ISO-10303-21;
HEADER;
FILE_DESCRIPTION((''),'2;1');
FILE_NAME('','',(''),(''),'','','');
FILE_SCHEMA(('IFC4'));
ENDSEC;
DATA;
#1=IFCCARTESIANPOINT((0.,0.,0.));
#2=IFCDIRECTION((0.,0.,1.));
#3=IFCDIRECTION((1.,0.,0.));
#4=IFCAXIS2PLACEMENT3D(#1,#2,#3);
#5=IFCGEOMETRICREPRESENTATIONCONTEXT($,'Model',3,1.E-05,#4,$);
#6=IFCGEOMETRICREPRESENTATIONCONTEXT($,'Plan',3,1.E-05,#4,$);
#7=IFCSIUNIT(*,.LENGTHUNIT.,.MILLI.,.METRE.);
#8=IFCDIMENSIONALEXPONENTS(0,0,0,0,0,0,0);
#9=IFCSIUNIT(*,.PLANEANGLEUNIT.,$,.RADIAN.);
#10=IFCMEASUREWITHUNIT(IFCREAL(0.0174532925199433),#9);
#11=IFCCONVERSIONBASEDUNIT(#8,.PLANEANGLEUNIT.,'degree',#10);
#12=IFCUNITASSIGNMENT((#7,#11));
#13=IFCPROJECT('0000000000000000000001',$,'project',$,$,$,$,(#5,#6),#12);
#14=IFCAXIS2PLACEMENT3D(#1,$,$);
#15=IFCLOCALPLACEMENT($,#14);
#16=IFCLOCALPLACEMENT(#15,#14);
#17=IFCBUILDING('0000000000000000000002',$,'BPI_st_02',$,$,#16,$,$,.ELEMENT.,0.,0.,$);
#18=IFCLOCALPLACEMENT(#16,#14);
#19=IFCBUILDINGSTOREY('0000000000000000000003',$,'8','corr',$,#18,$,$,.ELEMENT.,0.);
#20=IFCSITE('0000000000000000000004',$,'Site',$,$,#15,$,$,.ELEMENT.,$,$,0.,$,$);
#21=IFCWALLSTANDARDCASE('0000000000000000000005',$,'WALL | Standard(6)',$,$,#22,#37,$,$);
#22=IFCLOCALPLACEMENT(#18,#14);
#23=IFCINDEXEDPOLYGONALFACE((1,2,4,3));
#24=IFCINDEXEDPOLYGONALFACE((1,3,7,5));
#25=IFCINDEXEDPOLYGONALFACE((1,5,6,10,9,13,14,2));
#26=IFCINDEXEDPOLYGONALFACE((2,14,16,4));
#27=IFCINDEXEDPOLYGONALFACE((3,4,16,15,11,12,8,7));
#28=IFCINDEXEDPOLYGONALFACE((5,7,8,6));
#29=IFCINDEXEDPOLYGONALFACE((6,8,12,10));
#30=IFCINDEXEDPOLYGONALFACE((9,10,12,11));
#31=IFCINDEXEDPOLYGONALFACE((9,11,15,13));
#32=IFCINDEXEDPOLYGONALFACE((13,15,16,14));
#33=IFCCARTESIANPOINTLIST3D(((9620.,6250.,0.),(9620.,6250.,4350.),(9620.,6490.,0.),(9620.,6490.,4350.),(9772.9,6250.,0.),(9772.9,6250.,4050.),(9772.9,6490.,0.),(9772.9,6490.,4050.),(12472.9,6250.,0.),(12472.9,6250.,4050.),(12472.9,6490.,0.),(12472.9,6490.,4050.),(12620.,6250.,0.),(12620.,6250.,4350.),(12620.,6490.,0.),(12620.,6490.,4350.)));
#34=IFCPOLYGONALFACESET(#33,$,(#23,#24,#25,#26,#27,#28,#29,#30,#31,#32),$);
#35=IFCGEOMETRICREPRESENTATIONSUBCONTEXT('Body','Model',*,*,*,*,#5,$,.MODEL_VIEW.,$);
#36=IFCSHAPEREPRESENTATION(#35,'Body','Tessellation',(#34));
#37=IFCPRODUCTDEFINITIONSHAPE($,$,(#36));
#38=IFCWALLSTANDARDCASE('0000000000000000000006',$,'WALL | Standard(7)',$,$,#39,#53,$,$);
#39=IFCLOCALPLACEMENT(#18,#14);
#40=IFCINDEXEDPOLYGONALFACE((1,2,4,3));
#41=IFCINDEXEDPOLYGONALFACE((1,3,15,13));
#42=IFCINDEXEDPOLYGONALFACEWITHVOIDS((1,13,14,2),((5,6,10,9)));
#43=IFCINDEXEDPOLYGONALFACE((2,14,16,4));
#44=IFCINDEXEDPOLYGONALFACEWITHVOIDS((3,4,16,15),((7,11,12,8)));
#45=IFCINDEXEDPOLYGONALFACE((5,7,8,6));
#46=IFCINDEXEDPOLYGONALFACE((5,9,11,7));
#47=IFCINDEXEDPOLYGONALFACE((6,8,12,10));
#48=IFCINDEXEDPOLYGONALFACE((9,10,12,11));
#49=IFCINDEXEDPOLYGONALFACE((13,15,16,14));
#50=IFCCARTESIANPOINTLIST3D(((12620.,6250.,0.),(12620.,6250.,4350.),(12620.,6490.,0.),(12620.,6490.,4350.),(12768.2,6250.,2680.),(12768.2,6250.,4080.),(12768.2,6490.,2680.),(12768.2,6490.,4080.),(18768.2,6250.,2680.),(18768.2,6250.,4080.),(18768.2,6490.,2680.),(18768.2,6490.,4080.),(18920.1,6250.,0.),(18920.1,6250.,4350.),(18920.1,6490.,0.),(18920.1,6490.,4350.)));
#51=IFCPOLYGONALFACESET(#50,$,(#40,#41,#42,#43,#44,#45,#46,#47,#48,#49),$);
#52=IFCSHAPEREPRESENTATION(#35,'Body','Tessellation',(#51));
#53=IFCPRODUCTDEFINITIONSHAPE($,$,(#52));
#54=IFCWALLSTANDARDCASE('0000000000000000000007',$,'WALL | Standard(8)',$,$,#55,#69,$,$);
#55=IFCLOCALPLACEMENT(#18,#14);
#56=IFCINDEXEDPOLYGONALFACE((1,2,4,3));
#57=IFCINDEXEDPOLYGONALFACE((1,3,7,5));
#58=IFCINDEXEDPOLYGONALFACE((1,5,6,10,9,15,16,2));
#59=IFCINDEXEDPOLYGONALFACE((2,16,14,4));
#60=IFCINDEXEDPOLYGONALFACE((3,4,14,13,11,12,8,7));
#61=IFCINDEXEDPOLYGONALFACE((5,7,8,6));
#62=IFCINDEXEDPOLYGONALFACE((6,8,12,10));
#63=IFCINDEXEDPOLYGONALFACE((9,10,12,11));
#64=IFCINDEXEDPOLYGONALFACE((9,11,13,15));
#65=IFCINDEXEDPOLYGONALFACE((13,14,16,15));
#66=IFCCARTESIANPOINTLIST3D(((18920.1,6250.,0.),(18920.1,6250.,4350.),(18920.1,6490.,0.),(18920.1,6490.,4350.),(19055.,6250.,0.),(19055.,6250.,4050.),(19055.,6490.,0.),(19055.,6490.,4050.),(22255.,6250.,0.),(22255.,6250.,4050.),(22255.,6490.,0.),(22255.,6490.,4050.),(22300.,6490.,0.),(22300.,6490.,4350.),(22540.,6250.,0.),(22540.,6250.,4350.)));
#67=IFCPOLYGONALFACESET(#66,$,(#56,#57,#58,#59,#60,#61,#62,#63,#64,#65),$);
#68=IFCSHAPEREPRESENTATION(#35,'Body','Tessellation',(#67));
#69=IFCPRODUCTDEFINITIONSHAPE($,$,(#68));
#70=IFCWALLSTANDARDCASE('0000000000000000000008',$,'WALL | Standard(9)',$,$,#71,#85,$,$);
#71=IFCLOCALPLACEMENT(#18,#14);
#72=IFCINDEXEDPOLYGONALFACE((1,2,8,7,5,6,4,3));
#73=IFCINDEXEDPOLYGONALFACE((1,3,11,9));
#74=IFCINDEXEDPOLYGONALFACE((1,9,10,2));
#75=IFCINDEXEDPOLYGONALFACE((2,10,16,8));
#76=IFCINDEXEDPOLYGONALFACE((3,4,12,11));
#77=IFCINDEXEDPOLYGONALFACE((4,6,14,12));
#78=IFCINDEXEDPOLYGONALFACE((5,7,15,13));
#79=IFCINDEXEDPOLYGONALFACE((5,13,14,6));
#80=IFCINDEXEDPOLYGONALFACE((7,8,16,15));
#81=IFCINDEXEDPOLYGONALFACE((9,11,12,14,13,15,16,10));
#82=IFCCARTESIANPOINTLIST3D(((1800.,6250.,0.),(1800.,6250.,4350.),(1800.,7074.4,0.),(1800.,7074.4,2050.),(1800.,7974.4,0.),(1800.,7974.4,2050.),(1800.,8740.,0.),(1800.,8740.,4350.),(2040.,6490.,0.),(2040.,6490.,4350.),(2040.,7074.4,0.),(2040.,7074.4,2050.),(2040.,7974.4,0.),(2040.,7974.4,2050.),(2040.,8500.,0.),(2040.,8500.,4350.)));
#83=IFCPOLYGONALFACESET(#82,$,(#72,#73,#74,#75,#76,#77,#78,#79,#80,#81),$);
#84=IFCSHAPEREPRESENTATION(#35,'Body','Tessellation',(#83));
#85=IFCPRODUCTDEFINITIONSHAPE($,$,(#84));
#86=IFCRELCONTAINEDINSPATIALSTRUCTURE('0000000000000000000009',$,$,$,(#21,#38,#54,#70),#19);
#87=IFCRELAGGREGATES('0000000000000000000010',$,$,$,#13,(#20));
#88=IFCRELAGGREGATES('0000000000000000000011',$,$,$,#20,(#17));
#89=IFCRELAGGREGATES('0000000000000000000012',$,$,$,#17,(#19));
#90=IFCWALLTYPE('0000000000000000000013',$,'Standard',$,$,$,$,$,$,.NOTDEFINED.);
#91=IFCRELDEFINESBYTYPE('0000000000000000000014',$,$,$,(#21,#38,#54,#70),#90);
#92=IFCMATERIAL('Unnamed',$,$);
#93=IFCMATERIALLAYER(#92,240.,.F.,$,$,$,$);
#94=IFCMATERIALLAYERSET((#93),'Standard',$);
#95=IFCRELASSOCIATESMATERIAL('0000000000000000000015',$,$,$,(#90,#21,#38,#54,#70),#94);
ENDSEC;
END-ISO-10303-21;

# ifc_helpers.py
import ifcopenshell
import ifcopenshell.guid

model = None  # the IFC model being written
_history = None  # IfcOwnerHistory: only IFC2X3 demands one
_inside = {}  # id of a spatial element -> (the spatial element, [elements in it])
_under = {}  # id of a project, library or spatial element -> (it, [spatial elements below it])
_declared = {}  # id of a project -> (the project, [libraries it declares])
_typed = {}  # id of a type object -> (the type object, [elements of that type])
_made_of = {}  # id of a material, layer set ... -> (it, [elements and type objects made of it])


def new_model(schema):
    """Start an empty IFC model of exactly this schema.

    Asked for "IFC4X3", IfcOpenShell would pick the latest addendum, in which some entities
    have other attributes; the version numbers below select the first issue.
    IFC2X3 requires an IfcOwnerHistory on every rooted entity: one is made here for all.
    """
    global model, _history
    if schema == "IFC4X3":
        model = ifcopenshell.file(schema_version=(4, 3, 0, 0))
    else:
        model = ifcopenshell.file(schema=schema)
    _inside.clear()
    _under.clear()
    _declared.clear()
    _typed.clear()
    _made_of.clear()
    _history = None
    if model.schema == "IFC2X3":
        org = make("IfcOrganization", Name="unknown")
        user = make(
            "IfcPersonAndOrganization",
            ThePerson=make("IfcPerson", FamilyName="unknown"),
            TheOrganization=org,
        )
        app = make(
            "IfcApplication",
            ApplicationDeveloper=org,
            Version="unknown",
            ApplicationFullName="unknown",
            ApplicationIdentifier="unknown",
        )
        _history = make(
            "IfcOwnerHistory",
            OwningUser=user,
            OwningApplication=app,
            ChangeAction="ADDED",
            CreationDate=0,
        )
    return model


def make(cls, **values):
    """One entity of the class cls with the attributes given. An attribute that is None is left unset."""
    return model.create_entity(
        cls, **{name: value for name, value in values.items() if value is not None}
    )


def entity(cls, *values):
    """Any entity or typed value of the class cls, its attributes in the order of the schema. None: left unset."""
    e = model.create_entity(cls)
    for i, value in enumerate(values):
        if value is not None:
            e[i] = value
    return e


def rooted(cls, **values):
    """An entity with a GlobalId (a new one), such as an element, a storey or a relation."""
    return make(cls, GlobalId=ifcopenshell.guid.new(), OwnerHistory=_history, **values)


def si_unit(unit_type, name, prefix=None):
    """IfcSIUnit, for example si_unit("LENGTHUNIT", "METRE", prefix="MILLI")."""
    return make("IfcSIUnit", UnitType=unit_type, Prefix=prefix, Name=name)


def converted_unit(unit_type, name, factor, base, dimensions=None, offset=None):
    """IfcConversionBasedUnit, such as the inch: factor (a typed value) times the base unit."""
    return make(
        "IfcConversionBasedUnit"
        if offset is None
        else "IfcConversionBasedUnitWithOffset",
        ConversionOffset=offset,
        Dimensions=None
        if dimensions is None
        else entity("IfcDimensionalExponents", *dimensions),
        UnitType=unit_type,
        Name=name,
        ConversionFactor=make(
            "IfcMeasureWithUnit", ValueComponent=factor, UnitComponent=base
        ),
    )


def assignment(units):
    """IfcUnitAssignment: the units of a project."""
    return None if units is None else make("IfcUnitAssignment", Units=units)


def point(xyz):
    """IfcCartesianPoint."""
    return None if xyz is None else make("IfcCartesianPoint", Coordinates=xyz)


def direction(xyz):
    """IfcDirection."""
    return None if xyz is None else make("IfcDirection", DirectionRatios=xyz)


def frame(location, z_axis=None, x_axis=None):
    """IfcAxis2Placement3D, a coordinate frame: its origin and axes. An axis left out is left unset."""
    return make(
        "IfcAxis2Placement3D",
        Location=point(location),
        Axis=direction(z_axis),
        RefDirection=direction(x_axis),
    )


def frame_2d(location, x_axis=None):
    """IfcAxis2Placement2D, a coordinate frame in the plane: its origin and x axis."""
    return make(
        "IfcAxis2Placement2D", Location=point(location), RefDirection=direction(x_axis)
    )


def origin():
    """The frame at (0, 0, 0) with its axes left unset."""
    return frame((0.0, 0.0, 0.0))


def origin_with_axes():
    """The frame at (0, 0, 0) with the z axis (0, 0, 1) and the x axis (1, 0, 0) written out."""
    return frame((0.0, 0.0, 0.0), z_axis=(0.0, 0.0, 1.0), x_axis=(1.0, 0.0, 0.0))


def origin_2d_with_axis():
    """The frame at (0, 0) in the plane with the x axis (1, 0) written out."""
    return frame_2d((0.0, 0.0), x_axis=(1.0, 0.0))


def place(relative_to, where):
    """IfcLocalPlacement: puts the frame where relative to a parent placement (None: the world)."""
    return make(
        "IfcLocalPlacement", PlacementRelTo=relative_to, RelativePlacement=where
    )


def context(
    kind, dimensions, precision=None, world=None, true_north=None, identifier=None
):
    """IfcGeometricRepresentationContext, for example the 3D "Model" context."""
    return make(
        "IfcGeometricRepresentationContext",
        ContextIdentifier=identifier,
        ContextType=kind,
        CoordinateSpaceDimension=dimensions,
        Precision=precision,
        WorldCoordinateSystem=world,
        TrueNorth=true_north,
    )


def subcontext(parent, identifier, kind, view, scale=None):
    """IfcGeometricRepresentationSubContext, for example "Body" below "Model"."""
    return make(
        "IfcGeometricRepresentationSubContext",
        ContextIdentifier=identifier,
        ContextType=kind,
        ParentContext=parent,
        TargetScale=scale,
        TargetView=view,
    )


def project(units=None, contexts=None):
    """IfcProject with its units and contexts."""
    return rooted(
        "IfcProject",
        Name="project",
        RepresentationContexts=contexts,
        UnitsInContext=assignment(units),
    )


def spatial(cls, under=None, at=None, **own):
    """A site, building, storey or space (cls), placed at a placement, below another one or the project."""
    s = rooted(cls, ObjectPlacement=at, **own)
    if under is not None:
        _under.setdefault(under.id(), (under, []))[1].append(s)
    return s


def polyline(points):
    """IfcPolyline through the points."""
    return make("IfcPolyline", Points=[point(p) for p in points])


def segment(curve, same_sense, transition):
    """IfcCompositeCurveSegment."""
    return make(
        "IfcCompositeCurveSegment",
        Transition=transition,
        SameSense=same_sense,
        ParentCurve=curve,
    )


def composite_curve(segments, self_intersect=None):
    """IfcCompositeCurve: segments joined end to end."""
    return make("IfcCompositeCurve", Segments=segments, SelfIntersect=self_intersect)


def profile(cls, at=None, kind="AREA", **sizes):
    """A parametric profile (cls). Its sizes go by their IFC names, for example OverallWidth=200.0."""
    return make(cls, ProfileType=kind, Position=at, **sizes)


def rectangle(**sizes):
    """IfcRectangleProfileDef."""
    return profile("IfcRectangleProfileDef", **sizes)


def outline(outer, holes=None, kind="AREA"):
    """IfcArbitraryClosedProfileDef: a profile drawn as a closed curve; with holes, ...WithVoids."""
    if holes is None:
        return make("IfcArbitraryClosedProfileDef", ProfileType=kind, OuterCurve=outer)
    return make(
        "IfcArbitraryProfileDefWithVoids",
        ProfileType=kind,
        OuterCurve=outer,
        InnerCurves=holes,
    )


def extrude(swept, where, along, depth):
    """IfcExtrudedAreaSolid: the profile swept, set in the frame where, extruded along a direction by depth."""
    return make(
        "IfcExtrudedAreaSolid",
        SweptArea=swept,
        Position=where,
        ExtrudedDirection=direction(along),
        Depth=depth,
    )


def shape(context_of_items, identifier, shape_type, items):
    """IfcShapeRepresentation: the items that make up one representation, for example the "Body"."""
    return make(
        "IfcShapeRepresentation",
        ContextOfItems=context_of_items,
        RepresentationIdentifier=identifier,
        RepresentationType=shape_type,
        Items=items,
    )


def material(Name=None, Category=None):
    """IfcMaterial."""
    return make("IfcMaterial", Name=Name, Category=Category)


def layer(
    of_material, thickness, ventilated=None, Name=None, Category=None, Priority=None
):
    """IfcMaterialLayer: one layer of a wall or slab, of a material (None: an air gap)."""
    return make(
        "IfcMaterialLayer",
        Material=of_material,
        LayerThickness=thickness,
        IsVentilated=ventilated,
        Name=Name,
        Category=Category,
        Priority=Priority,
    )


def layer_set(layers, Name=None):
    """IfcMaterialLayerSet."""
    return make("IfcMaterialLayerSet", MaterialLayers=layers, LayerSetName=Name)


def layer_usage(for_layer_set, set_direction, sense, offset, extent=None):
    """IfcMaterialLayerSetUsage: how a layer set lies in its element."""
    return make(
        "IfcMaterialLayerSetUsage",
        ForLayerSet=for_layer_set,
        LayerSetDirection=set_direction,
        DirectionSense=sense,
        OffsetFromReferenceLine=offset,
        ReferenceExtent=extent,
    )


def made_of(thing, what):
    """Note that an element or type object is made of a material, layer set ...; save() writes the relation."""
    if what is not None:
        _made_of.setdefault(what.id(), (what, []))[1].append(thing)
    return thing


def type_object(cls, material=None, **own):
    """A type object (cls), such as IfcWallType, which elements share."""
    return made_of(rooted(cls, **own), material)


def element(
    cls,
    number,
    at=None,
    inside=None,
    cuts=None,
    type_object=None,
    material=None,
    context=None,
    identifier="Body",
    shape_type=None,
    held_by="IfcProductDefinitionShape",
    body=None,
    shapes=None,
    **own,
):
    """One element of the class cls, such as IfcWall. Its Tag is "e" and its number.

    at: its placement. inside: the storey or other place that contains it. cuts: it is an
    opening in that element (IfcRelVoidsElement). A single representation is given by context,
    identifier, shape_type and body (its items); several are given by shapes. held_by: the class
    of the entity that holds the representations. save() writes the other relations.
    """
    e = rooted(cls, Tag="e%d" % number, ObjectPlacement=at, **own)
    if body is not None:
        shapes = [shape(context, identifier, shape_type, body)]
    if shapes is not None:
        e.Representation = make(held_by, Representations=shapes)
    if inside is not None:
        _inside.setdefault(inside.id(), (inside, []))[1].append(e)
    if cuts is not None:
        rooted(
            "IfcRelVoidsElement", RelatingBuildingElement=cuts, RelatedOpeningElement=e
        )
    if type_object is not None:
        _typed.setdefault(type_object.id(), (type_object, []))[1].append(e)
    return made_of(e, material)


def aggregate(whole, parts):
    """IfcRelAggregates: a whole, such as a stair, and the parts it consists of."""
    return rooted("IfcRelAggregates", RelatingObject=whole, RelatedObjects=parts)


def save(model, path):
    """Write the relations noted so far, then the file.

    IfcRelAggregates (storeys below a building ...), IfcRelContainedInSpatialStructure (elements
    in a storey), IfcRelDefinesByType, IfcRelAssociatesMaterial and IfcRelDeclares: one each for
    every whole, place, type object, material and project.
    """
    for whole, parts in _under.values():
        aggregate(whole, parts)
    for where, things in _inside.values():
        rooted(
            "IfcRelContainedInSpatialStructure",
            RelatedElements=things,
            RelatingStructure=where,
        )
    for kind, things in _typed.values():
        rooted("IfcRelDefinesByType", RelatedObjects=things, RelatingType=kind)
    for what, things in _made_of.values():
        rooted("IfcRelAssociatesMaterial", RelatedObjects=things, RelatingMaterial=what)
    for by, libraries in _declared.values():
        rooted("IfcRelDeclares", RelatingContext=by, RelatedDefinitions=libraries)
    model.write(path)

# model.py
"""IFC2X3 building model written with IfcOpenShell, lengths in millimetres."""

from ifc_helpers import new_model, entity, si_unit, converted_unit, frame, frame_2d, origin, origin_with_axes, origin_2d_with_axis, place, context, subcontext, project, spatial, polyline, segment, composite_curve, rectangle, outline, extrude, material, layer, layer_set, layer_usage, type_object, element, save


model = new_model("IFC2X3")

# Units and contexts
model_context = context("Model", 3, precision=1e-05, world=origin_with_axes())
plan_context = context("Plan", 3, precision=1e-05, world=origin_with_axes())
body_context = subcontext(model_context, "Body", "Model", "MODEL_VIEW")
ifc_project = project(units=[si_unit("LENGTHUNIT", "METRE", prefix="MILLI"), converted_unit("PLANEANGLEUNIT", "degree", entity("IfcReal", 0.0174532925199433), si_unit("PLANEANGLEUNIT", "RADIAN"), dimensions=[0, 0, 0, 0, 0, 0, 0])], contexts=[model_context, plan_context])

# Site, building, storey
site_placement = place(None, origin())
site = spatial("IfcSite", under=ifc_project, at=site_placement, Name="Site", CompositionType="ELEMENT", RefElevation=0.0)
building_placement = place(site_placement, origin())
building = spatial("IfcBuilding", under=site, at=building_placement, Name="BPI_st_02", CompositionType="ELEMENT", ElevationOfRefHeight=0.0, ElevationOfTerrain=0.0)
storey_placement = place(building_placement, origin())
storey = spatial("IfcBuildingStorey", under=building, at=storey_placement, Name="8", Description="corr", CompositionType="ELEMENT", Elevation=0.0)

# Shared definitions
ifc_material = material(Name="Unnamed")

# Shared definitions
ifc_layer_1 = layer(ifc_material, 240.0, ventilated=False)
ifc_layer_set_1 = layer_set([ifc_layer_1], Name="Standard")
wall_type = type_object("IfcWallType", Name="Standard", PredefinedType="NOTDEFINED", material=ifc_layer_set_1)

# Walls, openings
ifc_layer_usage_1 = layer_usage(ifc_layer_set_1, "AXIS2", "POSITIVE", -120.0)
wall_1_placement = place(storey_placement, frame((9620.0, 6370.0, 0.0)))
wall_1 = element("IfcWallStandardCase", 1, at=wall_1_placement, inside=storey, type_object=wall_type, material=ifc_layer_usage_1, Name="WALL | Standard(6)", context=body_context, shape_type="SweptSolid", body=[
    extrude(rectangle(XDim=240.0, YDim=3000.0, at=frame_2d((1500.0, 0.0), x_axis=(0.0, -1.0))), origin(), (0.0, 0.0, 1.0), 4350.0),
])
opening_1_placement = place(wall_1_placement, frame((152.9, 0.0, 0.0)))
element("IfcOpeningElement", 2, at=opening_1_placement, cuts=wall_1, context=body_context, shape_type="SweptSolid", body=[
    extrude(rectangle(XDim=2700.0, YDim=4050.0, at=origin_2d_with_axis()), frame((1350.0, 120.0, 2025.0), z_axis=(0.0, -1.0, 0.0), x_axis=(1.0, 0.0, 0.0)), (0.0, 0.0, 1.0), 240.0),
])
ifc_layer_usage_2 = layer_usage(ifc_layer_set_1, "AXIS2", "POSITIVE", -120.0)
wall_2_placement = place(storey_placement, frame((12620.0, 6370.0, 0.0)))
wall_2 = element("IfcWallStandardCase", 3, at=wall_2_placement, inside=storey, type_object=wall_type, material=ifc_layer_usage_2, Name="WALL | Standard(7)", context=body_context, shape_type="SweptSolid", body=[
    extrude(rectangle(XDim=240.0, YDim=6300.0, at=frame_2d((3150.0, 0.0), x_axis=(0.0, -1.0))), origin(), (0.0, 0.0, 1.0), 4350.0),
])
opening_2_placement = place(wall_2_placement, frame((148.2, 0.0, 2680.0)))
element("IfcOpeningElement", 4, at=opening_2_placement, cuts=wall_2, context=body_context, shape_type="SweptSolid", body=[
    extrude(rectangle(XDim=6000.0, YDim=1400.0, at=origin_2d_with_axis()), frame((3000.0, 120.0, 700.0), z_axis=(0.0, -1.0, 0.0), x_axis=(1.0, 0.0, 0.0)), (0.0, 0.0, 1.0), 240.0),
])
ifc_layer_usage_3 = layer_usage(ifc_layer_set_1, "AXIS2", "POSITIVE", -120.0)
wall_3_placement = place(storey_placement, frame((18920.1, 6370.0, 0.0)))
wall_3 = element("IfcWallStandardCase", 5, at=wall_3_placement, inside=storey, type_object=wall_type, material=ifc_layer_usage_3, Name="WALL | Standard(8)", context=body_context, shape_type="SweptSolid", body=[
    extrude(outline(composite_curve([segment(polyline([(0.0, 120.0), (0.0, -120.0)]), True, "CONTINUOUS"), segment(polyline([(0.0, -120.0), (3620.0, -120.0)]), True, "CONTINUOUS"), segment(polyline([(3620.0, -120.0), (3380.0, 120.0)]), True, "CONTINUOUS"), segment(polyline([(3380.0, 120.0), (0.0, 120.0)]), True, "CONTINUOUS")], self_intersect=False)), origin(), (0.0, 0.0, 1.0), 4350.0),
])
opening_3_placement = place(wall_3_placement, frame((135.0, 0.0, 0.0)))
element("IfcOpeningElement", 6, at=opening_3_placement, cuts=wall_3, context=body_context, shape_type="SweptSolid", body=[
    extrude(rectangle(XDim=3200.0, YDim=4050.0, at=origin_2d_with_axis()), frame((1600.0, 120.0, 2025.0), z_axis=(0.0, -1.0, 0.0), x_axis=(1.0, 0.0, 0.0)), (0.0, 0.0, 1.0), 240.0),
])
ifc_layer_usage_4 = layer_usage(ifc_layer_set_1, "AXIS2", "POSITIVE", -120.0)
wall_4_placement = place(storey_placement, frame((1920.0, 8620.0, 0.0), z_axis=(0.0, 0.0, 1.0), x_axis=(0.0, -1.0, 0.0)))
wall_4 = element("IfcWallStandardCase", 7, at=wall_4_placement, inside=storey, type_object=wall_type, material=ifc_layer_usage_4, Name="WALL | Standard(9)", context=body_context, shape_type="SweptSolid", body=[
    extrude(outline(composite_curve([segment(polyline([(120.0, 120.0), (-120.0, -120.0)]), True, "CONTINUOUS"), segment(polyline([(-120.0, -120.0), (2370.0, -120.0)]), True, "CONTINUOUS"), segment(polyline([(2370.0, -120.0), (2130.0, 120.0)]), True, "CONTINUOUS"), segment(polyline([(2130.0, 120.0), (120.0, 120.0)]), True, "CONTINUOUS")], self_intersect=False)), origin(), (0.0, 0.0, 1.0), 4350.0),
])
opening_4_placement = place(wall_4_placement, frame((645.6, 0.0, 0.0)))
element("IfcOpeningElement", 8, at=opening_4_placement, cuts=wall_4, context=body_context, shape_type="SweptSolid", body=[
    extrude(rectangle(XDim=900.0, YDim=2050.0, at=origin_2d_with_axis()), frame((450.0, 120.0, 1025.0), z_axis=(0.0, -1.0, 0.0), x_axis=(1.0, 0.0, 0.0)), (0.0, 0.0, 1.0), 240.0),
])

save(model, "model.ifc")
